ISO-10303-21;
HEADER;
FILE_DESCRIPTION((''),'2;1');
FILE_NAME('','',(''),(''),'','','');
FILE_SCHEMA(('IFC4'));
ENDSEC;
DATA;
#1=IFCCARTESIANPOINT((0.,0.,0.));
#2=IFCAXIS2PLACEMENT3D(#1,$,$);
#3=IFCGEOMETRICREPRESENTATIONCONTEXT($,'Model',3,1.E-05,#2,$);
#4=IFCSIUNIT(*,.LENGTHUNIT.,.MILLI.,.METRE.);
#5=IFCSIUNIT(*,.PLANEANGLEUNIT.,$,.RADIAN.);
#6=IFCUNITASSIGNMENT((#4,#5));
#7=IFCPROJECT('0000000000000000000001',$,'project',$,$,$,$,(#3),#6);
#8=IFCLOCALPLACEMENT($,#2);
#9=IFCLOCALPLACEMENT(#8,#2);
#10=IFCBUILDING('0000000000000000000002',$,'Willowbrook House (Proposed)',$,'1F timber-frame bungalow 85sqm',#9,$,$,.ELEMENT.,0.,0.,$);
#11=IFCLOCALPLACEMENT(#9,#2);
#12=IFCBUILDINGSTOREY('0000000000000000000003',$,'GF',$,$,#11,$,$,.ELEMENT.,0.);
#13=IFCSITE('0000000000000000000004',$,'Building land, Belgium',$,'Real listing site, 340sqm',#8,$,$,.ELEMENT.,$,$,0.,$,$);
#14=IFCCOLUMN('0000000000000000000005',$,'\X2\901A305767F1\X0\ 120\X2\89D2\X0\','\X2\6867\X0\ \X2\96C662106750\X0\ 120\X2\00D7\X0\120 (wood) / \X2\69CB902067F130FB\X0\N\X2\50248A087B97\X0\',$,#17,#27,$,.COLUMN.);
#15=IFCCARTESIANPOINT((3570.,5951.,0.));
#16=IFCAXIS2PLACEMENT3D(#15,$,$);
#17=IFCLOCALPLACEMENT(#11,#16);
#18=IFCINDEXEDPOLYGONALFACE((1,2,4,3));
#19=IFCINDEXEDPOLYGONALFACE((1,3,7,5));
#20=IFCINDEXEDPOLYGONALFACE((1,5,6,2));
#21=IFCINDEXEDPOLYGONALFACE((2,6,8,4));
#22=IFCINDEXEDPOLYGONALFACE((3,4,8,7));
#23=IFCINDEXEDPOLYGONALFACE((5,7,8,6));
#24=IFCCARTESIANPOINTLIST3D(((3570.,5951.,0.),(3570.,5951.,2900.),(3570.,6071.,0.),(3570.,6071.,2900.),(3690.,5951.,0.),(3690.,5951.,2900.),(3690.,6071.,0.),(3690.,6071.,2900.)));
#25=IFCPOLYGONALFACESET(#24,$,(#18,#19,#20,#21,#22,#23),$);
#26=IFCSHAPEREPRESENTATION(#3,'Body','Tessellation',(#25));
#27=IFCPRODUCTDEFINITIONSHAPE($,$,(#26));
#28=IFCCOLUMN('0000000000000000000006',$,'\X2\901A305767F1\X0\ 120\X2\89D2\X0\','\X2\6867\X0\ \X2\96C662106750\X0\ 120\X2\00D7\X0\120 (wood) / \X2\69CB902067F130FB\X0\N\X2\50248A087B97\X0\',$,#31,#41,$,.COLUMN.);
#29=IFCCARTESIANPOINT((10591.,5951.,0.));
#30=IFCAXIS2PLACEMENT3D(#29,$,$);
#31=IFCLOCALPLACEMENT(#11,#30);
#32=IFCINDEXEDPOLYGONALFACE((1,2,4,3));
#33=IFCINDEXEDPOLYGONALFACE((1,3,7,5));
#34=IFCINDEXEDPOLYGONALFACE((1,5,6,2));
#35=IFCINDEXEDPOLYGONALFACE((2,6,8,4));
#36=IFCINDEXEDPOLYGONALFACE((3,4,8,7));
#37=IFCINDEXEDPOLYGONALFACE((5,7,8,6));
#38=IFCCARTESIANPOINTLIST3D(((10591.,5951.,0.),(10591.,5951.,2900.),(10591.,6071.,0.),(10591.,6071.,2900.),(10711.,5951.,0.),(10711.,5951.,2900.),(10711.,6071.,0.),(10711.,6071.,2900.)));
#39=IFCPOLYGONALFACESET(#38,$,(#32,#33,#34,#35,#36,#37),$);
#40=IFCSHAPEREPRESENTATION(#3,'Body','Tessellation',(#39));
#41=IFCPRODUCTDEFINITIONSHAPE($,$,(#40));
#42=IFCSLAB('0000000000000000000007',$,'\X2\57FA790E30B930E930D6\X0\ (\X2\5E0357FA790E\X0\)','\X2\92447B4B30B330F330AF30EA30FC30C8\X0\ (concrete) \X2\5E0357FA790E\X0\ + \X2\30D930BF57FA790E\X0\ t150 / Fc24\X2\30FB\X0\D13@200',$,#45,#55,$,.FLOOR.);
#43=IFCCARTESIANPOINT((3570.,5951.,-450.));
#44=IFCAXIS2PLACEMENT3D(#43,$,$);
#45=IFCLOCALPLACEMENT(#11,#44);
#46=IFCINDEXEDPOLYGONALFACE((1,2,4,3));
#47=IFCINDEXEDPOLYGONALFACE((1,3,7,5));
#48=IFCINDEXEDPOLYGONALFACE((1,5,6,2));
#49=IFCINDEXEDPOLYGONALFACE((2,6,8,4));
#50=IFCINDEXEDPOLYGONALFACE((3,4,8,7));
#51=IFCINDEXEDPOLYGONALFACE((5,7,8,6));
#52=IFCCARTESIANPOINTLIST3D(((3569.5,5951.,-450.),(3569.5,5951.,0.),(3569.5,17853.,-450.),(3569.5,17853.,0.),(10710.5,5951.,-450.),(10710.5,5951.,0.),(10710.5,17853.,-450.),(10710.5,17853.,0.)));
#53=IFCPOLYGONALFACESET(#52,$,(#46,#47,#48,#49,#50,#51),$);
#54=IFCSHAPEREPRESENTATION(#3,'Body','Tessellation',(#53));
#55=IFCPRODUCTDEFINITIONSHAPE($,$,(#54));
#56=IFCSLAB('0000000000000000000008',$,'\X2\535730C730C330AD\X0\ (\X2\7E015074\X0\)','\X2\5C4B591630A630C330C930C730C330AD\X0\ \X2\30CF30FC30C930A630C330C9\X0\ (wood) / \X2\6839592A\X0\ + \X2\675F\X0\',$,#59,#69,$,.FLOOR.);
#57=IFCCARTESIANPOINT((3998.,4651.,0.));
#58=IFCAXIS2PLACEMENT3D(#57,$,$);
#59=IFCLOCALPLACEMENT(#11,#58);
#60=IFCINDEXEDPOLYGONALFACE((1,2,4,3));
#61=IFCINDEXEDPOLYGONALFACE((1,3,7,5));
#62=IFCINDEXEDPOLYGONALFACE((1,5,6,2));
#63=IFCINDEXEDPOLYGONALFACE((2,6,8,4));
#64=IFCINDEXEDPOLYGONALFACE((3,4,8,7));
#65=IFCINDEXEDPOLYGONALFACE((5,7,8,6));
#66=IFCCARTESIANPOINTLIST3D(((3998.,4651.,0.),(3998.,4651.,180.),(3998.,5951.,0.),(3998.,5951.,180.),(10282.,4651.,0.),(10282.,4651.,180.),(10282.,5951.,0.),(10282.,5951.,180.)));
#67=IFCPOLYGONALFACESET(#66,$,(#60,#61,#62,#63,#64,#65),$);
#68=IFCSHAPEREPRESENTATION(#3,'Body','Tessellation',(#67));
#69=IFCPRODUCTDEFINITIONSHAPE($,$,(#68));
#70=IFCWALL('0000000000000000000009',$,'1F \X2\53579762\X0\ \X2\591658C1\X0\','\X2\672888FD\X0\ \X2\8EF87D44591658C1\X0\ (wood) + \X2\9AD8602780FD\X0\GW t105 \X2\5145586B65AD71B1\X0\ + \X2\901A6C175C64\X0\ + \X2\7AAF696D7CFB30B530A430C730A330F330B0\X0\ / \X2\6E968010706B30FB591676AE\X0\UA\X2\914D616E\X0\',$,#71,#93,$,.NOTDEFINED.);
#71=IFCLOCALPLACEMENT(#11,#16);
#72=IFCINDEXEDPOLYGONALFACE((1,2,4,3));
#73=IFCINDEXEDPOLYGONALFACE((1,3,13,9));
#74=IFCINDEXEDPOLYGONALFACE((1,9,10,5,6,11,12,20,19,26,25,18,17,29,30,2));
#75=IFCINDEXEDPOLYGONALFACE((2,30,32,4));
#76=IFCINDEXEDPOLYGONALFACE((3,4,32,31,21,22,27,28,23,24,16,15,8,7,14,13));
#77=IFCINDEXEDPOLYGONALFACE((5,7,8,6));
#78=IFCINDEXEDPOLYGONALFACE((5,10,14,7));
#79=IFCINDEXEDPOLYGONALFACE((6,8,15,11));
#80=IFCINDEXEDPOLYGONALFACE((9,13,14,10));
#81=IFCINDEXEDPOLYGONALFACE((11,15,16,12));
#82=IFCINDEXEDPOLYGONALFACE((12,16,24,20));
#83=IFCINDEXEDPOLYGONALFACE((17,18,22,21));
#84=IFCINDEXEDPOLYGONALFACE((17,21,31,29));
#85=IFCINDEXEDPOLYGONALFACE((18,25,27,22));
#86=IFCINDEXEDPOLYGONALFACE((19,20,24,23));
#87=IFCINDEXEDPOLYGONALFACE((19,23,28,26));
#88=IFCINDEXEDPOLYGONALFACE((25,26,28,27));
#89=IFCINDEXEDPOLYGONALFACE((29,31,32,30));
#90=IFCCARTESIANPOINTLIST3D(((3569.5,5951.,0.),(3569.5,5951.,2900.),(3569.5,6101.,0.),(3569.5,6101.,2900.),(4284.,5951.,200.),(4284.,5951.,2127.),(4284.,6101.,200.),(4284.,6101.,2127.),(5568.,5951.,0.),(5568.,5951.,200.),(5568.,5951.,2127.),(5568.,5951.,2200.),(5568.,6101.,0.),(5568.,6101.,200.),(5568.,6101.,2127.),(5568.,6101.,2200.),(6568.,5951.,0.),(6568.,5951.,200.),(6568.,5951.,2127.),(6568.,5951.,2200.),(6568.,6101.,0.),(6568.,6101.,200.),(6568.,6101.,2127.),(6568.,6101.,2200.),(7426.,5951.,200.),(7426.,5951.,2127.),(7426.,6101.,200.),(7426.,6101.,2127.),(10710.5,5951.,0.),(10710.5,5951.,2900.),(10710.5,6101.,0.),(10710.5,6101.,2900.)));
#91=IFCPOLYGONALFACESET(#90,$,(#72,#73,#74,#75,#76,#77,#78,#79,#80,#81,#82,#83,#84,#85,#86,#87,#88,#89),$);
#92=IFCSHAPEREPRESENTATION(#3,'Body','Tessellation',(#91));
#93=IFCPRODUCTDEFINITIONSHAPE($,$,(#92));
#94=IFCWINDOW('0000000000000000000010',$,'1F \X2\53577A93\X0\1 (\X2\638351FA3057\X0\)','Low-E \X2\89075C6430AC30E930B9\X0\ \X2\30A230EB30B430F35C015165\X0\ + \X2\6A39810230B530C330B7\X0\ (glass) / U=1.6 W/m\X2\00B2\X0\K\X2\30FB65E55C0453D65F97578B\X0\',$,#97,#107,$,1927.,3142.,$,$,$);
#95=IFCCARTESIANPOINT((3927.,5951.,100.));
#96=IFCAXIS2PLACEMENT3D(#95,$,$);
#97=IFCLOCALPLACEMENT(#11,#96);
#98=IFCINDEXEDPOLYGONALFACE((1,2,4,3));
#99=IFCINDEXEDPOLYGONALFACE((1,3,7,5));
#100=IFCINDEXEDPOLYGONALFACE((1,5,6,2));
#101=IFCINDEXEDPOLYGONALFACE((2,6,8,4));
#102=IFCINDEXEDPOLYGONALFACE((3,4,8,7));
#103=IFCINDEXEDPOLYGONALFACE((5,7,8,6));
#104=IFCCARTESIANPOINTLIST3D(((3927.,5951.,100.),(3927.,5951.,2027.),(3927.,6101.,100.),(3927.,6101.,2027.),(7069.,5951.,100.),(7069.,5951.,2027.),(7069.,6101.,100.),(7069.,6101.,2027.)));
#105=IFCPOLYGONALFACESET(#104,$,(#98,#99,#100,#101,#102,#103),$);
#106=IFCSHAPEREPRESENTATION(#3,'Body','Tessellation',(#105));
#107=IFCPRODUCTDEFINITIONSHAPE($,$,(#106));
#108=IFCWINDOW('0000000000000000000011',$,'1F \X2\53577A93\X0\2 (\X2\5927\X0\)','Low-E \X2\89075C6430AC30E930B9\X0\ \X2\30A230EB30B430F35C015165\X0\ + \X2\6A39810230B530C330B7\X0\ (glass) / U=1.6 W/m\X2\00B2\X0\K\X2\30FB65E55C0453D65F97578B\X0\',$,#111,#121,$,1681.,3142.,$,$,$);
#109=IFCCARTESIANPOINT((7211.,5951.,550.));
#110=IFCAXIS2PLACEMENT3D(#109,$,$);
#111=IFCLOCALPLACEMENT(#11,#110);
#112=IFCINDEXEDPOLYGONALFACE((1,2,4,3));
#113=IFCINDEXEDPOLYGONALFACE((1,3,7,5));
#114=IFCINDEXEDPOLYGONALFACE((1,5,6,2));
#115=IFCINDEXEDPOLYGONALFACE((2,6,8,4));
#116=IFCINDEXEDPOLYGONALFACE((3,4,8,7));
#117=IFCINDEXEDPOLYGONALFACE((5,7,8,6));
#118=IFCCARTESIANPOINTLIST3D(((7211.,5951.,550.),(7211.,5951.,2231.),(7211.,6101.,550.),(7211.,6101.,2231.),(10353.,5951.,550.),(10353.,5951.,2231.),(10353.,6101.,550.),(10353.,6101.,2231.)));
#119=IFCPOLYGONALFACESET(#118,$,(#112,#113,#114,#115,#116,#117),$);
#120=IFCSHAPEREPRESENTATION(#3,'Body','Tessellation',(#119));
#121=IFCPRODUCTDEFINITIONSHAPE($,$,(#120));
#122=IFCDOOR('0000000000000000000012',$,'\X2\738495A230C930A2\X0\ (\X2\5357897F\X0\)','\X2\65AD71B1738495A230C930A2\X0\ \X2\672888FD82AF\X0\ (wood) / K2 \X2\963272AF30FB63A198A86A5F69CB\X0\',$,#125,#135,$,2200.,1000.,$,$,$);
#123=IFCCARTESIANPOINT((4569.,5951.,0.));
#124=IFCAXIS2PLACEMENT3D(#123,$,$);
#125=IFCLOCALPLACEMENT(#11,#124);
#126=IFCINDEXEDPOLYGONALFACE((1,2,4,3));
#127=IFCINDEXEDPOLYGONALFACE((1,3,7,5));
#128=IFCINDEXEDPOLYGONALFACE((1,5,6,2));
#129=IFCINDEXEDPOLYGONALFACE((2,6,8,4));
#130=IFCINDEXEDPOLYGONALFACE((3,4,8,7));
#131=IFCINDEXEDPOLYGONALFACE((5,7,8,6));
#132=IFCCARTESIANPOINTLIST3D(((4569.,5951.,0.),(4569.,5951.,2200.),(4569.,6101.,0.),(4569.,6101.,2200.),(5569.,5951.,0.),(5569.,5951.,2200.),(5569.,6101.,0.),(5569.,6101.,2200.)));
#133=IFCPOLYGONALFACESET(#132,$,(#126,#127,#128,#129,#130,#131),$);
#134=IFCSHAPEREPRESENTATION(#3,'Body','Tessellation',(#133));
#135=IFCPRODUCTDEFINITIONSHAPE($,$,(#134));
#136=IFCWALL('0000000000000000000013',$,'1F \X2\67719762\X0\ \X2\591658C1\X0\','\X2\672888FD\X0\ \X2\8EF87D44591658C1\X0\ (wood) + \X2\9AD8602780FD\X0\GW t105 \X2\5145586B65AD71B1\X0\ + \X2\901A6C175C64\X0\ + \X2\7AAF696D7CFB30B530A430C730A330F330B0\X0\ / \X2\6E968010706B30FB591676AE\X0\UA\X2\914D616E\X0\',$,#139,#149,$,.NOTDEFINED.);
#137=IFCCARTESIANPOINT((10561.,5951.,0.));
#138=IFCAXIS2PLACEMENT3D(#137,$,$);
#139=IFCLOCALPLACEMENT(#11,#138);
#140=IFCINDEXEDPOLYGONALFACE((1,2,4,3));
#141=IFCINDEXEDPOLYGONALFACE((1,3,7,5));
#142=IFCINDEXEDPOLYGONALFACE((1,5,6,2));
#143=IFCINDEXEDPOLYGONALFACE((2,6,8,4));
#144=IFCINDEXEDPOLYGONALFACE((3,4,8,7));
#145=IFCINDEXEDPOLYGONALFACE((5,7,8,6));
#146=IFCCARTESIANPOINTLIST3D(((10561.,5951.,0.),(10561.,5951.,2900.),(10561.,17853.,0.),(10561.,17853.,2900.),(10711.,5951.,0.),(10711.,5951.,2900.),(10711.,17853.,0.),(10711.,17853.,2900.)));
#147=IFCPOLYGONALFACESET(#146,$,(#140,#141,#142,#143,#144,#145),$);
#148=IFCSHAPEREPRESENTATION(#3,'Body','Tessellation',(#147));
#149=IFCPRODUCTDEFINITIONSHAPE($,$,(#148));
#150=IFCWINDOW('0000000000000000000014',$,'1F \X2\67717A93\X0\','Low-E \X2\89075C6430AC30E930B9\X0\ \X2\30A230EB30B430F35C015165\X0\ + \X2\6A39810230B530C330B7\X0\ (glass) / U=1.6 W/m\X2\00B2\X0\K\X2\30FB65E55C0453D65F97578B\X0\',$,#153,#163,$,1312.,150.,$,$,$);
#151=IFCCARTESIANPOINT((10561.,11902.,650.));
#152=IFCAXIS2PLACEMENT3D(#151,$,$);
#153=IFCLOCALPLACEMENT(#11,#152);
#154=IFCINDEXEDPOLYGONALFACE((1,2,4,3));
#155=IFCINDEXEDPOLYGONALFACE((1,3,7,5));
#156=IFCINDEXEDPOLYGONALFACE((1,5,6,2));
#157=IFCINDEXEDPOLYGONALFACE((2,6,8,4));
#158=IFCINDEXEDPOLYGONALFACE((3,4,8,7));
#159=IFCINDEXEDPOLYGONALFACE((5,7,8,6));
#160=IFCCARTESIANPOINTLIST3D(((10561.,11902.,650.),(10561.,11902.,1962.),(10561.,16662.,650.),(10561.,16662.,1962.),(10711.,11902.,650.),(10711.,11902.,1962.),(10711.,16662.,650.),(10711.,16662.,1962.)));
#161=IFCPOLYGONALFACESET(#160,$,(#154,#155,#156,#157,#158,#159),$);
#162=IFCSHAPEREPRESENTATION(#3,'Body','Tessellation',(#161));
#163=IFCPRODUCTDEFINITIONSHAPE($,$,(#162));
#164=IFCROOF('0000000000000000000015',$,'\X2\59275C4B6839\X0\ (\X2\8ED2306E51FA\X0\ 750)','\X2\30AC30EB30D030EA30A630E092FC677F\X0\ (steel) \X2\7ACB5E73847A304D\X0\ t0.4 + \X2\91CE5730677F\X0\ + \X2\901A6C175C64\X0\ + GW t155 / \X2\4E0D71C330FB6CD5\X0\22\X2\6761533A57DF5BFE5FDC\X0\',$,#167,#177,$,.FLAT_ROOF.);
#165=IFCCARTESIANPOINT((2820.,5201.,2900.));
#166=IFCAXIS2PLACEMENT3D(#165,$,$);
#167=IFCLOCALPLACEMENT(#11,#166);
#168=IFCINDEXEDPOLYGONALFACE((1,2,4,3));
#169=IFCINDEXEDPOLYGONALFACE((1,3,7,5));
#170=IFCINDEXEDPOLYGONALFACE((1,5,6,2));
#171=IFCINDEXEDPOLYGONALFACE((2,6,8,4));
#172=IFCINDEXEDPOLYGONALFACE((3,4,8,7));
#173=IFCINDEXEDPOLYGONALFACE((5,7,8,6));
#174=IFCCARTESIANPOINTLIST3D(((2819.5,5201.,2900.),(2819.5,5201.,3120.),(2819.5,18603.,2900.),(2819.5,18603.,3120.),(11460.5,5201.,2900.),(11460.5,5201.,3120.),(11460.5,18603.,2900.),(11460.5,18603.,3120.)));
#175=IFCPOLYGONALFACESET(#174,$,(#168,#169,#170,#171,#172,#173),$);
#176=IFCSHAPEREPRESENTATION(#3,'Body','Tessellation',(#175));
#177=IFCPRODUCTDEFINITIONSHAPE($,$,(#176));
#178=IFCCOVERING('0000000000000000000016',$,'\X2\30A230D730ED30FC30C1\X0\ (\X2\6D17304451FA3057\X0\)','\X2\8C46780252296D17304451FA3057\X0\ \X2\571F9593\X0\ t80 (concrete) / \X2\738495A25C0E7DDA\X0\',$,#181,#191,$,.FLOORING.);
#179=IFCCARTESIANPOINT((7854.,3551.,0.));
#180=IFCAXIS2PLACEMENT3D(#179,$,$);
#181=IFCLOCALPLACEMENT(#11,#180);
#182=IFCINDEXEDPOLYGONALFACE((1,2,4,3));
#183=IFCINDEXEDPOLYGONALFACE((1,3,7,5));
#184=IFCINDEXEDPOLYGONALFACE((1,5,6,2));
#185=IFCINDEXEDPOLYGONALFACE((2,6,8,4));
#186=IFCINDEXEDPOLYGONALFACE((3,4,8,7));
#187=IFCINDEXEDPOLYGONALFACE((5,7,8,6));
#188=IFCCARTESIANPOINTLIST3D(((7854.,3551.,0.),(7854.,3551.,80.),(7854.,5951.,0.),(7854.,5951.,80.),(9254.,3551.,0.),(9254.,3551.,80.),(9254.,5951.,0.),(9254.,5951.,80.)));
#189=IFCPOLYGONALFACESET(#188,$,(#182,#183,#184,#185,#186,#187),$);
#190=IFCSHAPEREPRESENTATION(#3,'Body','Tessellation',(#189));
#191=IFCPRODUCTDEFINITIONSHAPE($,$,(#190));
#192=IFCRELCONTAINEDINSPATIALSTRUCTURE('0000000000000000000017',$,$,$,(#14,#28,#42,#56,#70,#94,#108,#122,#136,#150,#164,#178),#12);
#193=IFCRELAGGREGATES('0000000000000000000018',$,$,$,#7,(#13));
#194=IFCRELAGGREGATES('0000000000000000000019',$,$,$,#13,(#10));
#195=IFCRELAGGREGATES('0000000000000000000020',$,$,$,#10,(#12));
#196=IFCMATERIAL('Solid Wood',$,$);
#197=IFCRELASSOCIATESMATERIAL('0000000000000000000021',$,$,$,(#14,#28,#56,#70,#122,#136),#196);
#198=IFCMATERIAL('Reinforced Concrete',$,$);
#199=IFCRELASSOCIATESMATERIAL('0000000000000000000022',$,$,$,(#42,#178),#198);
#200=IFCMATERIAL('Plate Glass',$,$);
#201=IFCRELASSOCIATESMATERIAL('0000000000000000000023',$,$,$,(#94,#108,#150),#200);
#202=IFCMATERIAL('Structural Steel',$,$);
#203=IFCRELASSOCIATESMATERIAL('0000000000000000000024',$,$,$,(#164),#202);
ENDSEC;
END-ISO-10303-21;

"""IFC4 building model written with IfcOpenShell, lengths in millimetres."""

from ifc_helpers import new_model, si_unit, frame, frame_2d, origin, place, context, project, spatial, rectangle, extrude, material, element, fill, save


model = new_model("IFC4")

# Units and contexts
model_context = context("Model", 3, precision=1e-05, world=origin())
ifc_project = project(units=[si_unit("LENGTHUNIT", "METRE", prefix="MILLI"), si_unit("PLANEANGLEUNIT", "RADIAN")], contexts=[model_context])

# Site, building, storey
site_placement = place(None, origin())
site = spatial("IfcSite", under=ifc_project, at=site_placement, Name="Building land, Belgium", ObjectType="Real listing site, 340sqm", CompositionType="ELEMENT", RefElevation=0.0)
building_placement = place(site_placement, origin())
building = spatial("IfcBuilding", under=site, at=building_placement, Name="Willowbrook House (Proposed)", ObjectType="1F timber-frame bungalow 85sqm", CompositionType="ELEMENT", ElevationOfRefHeight=0.0, ElevationOfTerrain=0.0)
storey_placement = place(building_placement, origin())
storey = spatial("IfcBuildingStorey", under=building, at=storey_placement, Name="GF", CompositionType="ELEMENT", Elevation=0.0)

# Columns
ifc_material_1 = material(Name="Solid Wood")
column_1_placement = place(storey_placement, frame((3570.0, 5951.0, 0.0)))
element("IfcColumn", 1, at=column_1_placement, inside=storey, material=ifc_material_1, Name="通し柱 120角", Description="桧 集成材 120×120 (wood) / 構造柱・N値計算", PredefinedType="COLUMN", context=model_context, shape_type="SweptSolid", body=[
    extrude(rectangle(XDim=120.0, YDim=120.0, at=frame_2d((60.0, 60.0))), frame((3570.0, 5951.0, 0.0)), (0.0, 0.0, 1.0), 2900.0),
])
column_2_placement = place(storey_placement, frame((10591.0, 5951.0, 0.0)))
element("IfcColumn", 2, at=column_2_placement, inside=storey, material=ifc_material_1, Name="通し柱 120角", Description="桧 集成材 120×120 (wood) / 構造柱・N値計算", PredefinedType="COLUMN", context=model_context, shape_type="SweptSolid", body=[
    extrude(rectangle(XDim=120.0, YDim=120.0, at=frame_2d((60.0, 60.0))), frame((10591.0, 5951.0, 0.0)), (0.0, 0.0, 1.0), 2900.0),
])

# Slabs
ifc_material_2 = material(Name="Reinforced Concrete")
slab_1_placement = place(storey_placement, frame((3570.0, 5951.0, -450.0)))
element("IfcSlab", 3, at=slab_1_placement, inside=storey, material=ifc_material_2, Name="基礎スラブ (布基礎)", Description="鉄筋コンクリート (concrete) 布基礎 + ベタ基礎 t150 / Fc24・D13@200", PredefinedType="FLOOR", context=model_context, shape_type="SweptSolid", body=[
    extrude(rectangle(XDim=7141.0, YDim=11902.0, at=frame_2d((3570.0, 5951.0))), frame((3570.0, 5951.0, -450.0)), (0.0, 0.0, 1.0), 450.0),
])
slab_2_placement = place(storey_placement, frame((3998.0, 4651.0, 0.0)))
element("IfcSlab", 4, at=slab_2_placement, inside=storey, material=ifc_material_1, Name="南デッキ (縁側)", Description="屋外ウッドデッキ ハードウッド (wood) / 根太 + 束", PredefinedType="FLOOR", context=model_context, shape_type="SweptSolid", body=[
    extrude(rectangle(XDim=6284.0, YDim=1300.0, at=frame_2d((3142.0, 650.0))), frame((3998.0, 4651.0, 0.0)), (0.0, 0.0, 1.0), 180.0),
])

# Wall, openings, windows, door
wall_1_placement = place(storey_placement, frame((3570.0, 5951.0, 0.0)))
wall_1 = element("IfcWall", 5, at=wall_1_placement, inside=storey, material=ifc_material_1, Name="1F 南面 外壁", Description="木製 軸組外壁 (wood) + 高性能GW t105 充填断熱 + 通気層 + 窯業系サイディング / 準耐火・外皮UA配慮", PredefinedType="NOTDEFINED", context=model_context, shape_type="SweptSolid", body=[
    extrude(rectangle(XDim=7141.0, YDim=150.0, at=frame_2d((3570.0, 75.0))), frame((3570.0, 5951.0, 0.0)), (0.0, 0.0, 1.0), 2900.0),
])
opening_1_placement = place(storey_placement, frame((3927.0, 5951.0, 100.0)))
opening_1 = element("IfcOpeningElement", 6, at=opening_1_placement, cuts=wall_1, PredefinedType="NOTDEFINED", context=model_context, shape_type="SweptSolid", body=[
    extrude(rectangle(XDim=3142.0, YDim=150.0, at=frame_2d((1571.0, 75.0))), frame((3927.0, 5951.0, 100.0)), (0.0, 0.0, 1.0), 1927.0),
])
opening_2_placement = place(storey_placement, frame((7211.0, 5951.0, 550.0)))
opening_2 = element("IfcOpeningElement", 7, at=opening_2_placement, cuts=wall_1, PredefinedType="NOTDEFINED", context=model_context, shape_type="SweptSolid", body=[
    extrude(rectangle(XDim=3142.0, YDim=150.0, at=frame_2d((1571.0, 75.0))), frame((7211.0, 5951.0, 550.0)), (0.0, 0.0, 1.0), 1681.0),
])
opening_3_placement = place(storey_placement, frame((4569.0, 5951.0, 0.0)))
opening_3 = element("IfcOpeningElement", 8, at=opening_3_placement, cuts=wall_1, PredefinedType="NOTDEFINED", context=model_context, shape_type="SweptSolid", body=[
    extrude(rectangle(XDim=1000.0, YDim=150.0, at=frame_2d((500.0, 75.0))), frame((4569.0, 5951.0, 0.0)), (0.0, 0.0, 1.0), 2200.0),
])
ifc_material_3 = material(Name="Plate Glass")
window_1_placement = place(storey_placement, frame((3927.0, 5951.0, 100.0)))
window_1 = element("IfcWindow", 9, at=window_1_placement, inside=storey, material=ifc_material_3, Name="1F 南窓1 (掃出し)", Description="Low-E 複層ガラス アルゴン封入 + 樹脂サッシ (glass) / U=1.6 W/m²K・日射取得型", OverallHeight=1927.0, OverallWidth=3142.0, context=model_context, shape_type="SweptSolid", body=[
    extrude(rectangle(XDim=3142.0, YDim=150.0, at=frame_2d((1571.0, 75.0))), frame((3927.0, 5951.0, 100.0)), (0.0, 0.0, 1.0), 1927.0),
])
fill(opening_1, window_1)
window_2_placement = place(storey_placement, frame((7211.0, 5951.0, 550.0)))
window_2 = element("IfcWindow", 10, at=window_2_placement, inside=storey, material=ifc_material_3, Name="1F 南窓2 (大)", Description="Low-E 複層ガラス アルゴン封入 + 樹脂サッシ (glass) / U=1.6 W/m²K・日射取得型", OverallHeight=1681.0, OverallWidth=3142.0, context=model_context, shape_type="SweptSolid", body=[
    extrude(rectangle(XDim=3142.0, YDim=150.0, at=frame_2d((1571.0, 75.0))), frame((7211.0, 5951.0, 550.0)), (0.0, 0.0, 1.0), 1681.0),
])
fill(opening_2, window_2)
door_placement = place(storey_placement, frame((4569.0, 5951.0, 0.0)))
door = element("IfcDoor", 11, at=door_placement, inside=storey, material=ifc_material_1, Name="玄関ドア (南西)", Description="断熱玄関ドア 木製芯 (wood) / K2 防犯・採風機構", OverallHeight=2200.0, OverallWidth=1000.0, context=model_context, shape_type="SweptSolid", body=[
    extrude(rectangle(XDim=1000.0, YDim=150.0, at=frame_2d((500.0, 75.0))), frame((4569.0, 5951.0, 0.0)), (0.0, 0.0, 1.0), 2200.0),
])
fill(opening_3, door)

# Wall, opening, window
wall_2_placement = place(storey_placement, frame((10561.0, 5951.0, 0.0)))
wall_2 = element("IfcWall", 12, at=wall_2_placement, inside=storey, material=ifc_material_1, Name="1F 東面 外壁", Description="木製 軸組外壁 (wood) + 高性能GW t105 充填断熱 + 通気層 + 窯業系サイディング / 準耐火・外皮UA配慮", PredefinedType="NOTDEFINED", context=model_context, shape_type="SweptSolid", body=[
    extrude(rectangle(XDim=150.0, YDim=11902.0, at=frame_2d((75.0, 5951.0))), frame((10561.0, 5951.0, 0.0)), (0.0, 0.0, 1.0), 2900.0),
])
opening_4_placement = place(storey_placement, frame((10561.0, 11902.0, 650.0)))
opening_4 = element("IfcOpeningElement", 13, at=opening_4_placement, cuts=wall_2, PredefinedType="NOTDEFINED", context=model_context, shape_type="SweptSolid", body=[
    extrude(rectangle(XDim=150.0, YDim=4760.0, at=frame_2d((75.0, 2380.0))), frame((10561.0, 11902.0, 650.0)), (0.0, 0.0, 1.0), 1312.0),
])
window_3_placement = place(storey_placement, frame((10561.0, 11902.0, 650.0)))
window_3 = element("IfcWindow", 14, at=window_3_placement, inside=storey, material=ifc_material_3, Name="1F 東窓", Description="Low-E 複層ガラス アルゴン封入 + 樹脂サッシ (glass) / U=1.6 W/m²K・日射取得型", OverallHeight=1312.0, OverallWidth=150.0, context=model_context, shape_type="SweptSolid", body=[
    extrude(rectangle(XDim=150.0, YDim=4760.0, at=frame_2d((75.0, 2380.0))), frame((10561.0, 11902.0, 650.0)), (0.0, 0.0, 1.0), 1312.0),
])
fill(opening_4, window_3)

# Roof
ifc_material_4 = material(Name="Structural Steel")
roof_placement = place(storey_placement, frame((2820.0, 5201.0, 2900.0)))
element("IfcRoof", 15, at=roof_placement, inside=storey, material=ifc_material_4, Name="大屋根 (軒の出 750)", Description="ガルバリウム鋼板 (steel) 立平葺き t0.4 + 野地板 + 通気層 + GW t155 / 不燃・法22条区域対応", PredefinedType="FLAT_ROOF", context=model_context, shape_type="SweptSolid", body=[
    extrude(rectangle(XDim=8641.0, YDim=13402.0, at=frame_2d((4320.0, 6701.0))), frame((2820.0, 5201.0, 2900.0)), (0.0, 0.0, 1.0), 220.0),
])

# Covering
covering_1_placement = place(storey_placement, frame((7854.0, 3551.0, 0.0)))
element("IfcCovering", 16, at=covering_1_placement, inside=storey, material=ifc_material_2, Name="アプローチ (洗い出し)", Description="豆砂利洗い出し 土間 t80 (concrete) / 玄関導線", PredefinedType="FLOORING", context=model_context, shape_type="SweptSolid", body=[
    extrude(rectangle(XDim=1400.0, YDim=2400.0, at=frame_2d((700.0, 1200.0))), frame((7854.0, 3551.0, 0.0)), (0.0, 0.0, 1.0), 80.0),
])

save(model, "model.ifc")
